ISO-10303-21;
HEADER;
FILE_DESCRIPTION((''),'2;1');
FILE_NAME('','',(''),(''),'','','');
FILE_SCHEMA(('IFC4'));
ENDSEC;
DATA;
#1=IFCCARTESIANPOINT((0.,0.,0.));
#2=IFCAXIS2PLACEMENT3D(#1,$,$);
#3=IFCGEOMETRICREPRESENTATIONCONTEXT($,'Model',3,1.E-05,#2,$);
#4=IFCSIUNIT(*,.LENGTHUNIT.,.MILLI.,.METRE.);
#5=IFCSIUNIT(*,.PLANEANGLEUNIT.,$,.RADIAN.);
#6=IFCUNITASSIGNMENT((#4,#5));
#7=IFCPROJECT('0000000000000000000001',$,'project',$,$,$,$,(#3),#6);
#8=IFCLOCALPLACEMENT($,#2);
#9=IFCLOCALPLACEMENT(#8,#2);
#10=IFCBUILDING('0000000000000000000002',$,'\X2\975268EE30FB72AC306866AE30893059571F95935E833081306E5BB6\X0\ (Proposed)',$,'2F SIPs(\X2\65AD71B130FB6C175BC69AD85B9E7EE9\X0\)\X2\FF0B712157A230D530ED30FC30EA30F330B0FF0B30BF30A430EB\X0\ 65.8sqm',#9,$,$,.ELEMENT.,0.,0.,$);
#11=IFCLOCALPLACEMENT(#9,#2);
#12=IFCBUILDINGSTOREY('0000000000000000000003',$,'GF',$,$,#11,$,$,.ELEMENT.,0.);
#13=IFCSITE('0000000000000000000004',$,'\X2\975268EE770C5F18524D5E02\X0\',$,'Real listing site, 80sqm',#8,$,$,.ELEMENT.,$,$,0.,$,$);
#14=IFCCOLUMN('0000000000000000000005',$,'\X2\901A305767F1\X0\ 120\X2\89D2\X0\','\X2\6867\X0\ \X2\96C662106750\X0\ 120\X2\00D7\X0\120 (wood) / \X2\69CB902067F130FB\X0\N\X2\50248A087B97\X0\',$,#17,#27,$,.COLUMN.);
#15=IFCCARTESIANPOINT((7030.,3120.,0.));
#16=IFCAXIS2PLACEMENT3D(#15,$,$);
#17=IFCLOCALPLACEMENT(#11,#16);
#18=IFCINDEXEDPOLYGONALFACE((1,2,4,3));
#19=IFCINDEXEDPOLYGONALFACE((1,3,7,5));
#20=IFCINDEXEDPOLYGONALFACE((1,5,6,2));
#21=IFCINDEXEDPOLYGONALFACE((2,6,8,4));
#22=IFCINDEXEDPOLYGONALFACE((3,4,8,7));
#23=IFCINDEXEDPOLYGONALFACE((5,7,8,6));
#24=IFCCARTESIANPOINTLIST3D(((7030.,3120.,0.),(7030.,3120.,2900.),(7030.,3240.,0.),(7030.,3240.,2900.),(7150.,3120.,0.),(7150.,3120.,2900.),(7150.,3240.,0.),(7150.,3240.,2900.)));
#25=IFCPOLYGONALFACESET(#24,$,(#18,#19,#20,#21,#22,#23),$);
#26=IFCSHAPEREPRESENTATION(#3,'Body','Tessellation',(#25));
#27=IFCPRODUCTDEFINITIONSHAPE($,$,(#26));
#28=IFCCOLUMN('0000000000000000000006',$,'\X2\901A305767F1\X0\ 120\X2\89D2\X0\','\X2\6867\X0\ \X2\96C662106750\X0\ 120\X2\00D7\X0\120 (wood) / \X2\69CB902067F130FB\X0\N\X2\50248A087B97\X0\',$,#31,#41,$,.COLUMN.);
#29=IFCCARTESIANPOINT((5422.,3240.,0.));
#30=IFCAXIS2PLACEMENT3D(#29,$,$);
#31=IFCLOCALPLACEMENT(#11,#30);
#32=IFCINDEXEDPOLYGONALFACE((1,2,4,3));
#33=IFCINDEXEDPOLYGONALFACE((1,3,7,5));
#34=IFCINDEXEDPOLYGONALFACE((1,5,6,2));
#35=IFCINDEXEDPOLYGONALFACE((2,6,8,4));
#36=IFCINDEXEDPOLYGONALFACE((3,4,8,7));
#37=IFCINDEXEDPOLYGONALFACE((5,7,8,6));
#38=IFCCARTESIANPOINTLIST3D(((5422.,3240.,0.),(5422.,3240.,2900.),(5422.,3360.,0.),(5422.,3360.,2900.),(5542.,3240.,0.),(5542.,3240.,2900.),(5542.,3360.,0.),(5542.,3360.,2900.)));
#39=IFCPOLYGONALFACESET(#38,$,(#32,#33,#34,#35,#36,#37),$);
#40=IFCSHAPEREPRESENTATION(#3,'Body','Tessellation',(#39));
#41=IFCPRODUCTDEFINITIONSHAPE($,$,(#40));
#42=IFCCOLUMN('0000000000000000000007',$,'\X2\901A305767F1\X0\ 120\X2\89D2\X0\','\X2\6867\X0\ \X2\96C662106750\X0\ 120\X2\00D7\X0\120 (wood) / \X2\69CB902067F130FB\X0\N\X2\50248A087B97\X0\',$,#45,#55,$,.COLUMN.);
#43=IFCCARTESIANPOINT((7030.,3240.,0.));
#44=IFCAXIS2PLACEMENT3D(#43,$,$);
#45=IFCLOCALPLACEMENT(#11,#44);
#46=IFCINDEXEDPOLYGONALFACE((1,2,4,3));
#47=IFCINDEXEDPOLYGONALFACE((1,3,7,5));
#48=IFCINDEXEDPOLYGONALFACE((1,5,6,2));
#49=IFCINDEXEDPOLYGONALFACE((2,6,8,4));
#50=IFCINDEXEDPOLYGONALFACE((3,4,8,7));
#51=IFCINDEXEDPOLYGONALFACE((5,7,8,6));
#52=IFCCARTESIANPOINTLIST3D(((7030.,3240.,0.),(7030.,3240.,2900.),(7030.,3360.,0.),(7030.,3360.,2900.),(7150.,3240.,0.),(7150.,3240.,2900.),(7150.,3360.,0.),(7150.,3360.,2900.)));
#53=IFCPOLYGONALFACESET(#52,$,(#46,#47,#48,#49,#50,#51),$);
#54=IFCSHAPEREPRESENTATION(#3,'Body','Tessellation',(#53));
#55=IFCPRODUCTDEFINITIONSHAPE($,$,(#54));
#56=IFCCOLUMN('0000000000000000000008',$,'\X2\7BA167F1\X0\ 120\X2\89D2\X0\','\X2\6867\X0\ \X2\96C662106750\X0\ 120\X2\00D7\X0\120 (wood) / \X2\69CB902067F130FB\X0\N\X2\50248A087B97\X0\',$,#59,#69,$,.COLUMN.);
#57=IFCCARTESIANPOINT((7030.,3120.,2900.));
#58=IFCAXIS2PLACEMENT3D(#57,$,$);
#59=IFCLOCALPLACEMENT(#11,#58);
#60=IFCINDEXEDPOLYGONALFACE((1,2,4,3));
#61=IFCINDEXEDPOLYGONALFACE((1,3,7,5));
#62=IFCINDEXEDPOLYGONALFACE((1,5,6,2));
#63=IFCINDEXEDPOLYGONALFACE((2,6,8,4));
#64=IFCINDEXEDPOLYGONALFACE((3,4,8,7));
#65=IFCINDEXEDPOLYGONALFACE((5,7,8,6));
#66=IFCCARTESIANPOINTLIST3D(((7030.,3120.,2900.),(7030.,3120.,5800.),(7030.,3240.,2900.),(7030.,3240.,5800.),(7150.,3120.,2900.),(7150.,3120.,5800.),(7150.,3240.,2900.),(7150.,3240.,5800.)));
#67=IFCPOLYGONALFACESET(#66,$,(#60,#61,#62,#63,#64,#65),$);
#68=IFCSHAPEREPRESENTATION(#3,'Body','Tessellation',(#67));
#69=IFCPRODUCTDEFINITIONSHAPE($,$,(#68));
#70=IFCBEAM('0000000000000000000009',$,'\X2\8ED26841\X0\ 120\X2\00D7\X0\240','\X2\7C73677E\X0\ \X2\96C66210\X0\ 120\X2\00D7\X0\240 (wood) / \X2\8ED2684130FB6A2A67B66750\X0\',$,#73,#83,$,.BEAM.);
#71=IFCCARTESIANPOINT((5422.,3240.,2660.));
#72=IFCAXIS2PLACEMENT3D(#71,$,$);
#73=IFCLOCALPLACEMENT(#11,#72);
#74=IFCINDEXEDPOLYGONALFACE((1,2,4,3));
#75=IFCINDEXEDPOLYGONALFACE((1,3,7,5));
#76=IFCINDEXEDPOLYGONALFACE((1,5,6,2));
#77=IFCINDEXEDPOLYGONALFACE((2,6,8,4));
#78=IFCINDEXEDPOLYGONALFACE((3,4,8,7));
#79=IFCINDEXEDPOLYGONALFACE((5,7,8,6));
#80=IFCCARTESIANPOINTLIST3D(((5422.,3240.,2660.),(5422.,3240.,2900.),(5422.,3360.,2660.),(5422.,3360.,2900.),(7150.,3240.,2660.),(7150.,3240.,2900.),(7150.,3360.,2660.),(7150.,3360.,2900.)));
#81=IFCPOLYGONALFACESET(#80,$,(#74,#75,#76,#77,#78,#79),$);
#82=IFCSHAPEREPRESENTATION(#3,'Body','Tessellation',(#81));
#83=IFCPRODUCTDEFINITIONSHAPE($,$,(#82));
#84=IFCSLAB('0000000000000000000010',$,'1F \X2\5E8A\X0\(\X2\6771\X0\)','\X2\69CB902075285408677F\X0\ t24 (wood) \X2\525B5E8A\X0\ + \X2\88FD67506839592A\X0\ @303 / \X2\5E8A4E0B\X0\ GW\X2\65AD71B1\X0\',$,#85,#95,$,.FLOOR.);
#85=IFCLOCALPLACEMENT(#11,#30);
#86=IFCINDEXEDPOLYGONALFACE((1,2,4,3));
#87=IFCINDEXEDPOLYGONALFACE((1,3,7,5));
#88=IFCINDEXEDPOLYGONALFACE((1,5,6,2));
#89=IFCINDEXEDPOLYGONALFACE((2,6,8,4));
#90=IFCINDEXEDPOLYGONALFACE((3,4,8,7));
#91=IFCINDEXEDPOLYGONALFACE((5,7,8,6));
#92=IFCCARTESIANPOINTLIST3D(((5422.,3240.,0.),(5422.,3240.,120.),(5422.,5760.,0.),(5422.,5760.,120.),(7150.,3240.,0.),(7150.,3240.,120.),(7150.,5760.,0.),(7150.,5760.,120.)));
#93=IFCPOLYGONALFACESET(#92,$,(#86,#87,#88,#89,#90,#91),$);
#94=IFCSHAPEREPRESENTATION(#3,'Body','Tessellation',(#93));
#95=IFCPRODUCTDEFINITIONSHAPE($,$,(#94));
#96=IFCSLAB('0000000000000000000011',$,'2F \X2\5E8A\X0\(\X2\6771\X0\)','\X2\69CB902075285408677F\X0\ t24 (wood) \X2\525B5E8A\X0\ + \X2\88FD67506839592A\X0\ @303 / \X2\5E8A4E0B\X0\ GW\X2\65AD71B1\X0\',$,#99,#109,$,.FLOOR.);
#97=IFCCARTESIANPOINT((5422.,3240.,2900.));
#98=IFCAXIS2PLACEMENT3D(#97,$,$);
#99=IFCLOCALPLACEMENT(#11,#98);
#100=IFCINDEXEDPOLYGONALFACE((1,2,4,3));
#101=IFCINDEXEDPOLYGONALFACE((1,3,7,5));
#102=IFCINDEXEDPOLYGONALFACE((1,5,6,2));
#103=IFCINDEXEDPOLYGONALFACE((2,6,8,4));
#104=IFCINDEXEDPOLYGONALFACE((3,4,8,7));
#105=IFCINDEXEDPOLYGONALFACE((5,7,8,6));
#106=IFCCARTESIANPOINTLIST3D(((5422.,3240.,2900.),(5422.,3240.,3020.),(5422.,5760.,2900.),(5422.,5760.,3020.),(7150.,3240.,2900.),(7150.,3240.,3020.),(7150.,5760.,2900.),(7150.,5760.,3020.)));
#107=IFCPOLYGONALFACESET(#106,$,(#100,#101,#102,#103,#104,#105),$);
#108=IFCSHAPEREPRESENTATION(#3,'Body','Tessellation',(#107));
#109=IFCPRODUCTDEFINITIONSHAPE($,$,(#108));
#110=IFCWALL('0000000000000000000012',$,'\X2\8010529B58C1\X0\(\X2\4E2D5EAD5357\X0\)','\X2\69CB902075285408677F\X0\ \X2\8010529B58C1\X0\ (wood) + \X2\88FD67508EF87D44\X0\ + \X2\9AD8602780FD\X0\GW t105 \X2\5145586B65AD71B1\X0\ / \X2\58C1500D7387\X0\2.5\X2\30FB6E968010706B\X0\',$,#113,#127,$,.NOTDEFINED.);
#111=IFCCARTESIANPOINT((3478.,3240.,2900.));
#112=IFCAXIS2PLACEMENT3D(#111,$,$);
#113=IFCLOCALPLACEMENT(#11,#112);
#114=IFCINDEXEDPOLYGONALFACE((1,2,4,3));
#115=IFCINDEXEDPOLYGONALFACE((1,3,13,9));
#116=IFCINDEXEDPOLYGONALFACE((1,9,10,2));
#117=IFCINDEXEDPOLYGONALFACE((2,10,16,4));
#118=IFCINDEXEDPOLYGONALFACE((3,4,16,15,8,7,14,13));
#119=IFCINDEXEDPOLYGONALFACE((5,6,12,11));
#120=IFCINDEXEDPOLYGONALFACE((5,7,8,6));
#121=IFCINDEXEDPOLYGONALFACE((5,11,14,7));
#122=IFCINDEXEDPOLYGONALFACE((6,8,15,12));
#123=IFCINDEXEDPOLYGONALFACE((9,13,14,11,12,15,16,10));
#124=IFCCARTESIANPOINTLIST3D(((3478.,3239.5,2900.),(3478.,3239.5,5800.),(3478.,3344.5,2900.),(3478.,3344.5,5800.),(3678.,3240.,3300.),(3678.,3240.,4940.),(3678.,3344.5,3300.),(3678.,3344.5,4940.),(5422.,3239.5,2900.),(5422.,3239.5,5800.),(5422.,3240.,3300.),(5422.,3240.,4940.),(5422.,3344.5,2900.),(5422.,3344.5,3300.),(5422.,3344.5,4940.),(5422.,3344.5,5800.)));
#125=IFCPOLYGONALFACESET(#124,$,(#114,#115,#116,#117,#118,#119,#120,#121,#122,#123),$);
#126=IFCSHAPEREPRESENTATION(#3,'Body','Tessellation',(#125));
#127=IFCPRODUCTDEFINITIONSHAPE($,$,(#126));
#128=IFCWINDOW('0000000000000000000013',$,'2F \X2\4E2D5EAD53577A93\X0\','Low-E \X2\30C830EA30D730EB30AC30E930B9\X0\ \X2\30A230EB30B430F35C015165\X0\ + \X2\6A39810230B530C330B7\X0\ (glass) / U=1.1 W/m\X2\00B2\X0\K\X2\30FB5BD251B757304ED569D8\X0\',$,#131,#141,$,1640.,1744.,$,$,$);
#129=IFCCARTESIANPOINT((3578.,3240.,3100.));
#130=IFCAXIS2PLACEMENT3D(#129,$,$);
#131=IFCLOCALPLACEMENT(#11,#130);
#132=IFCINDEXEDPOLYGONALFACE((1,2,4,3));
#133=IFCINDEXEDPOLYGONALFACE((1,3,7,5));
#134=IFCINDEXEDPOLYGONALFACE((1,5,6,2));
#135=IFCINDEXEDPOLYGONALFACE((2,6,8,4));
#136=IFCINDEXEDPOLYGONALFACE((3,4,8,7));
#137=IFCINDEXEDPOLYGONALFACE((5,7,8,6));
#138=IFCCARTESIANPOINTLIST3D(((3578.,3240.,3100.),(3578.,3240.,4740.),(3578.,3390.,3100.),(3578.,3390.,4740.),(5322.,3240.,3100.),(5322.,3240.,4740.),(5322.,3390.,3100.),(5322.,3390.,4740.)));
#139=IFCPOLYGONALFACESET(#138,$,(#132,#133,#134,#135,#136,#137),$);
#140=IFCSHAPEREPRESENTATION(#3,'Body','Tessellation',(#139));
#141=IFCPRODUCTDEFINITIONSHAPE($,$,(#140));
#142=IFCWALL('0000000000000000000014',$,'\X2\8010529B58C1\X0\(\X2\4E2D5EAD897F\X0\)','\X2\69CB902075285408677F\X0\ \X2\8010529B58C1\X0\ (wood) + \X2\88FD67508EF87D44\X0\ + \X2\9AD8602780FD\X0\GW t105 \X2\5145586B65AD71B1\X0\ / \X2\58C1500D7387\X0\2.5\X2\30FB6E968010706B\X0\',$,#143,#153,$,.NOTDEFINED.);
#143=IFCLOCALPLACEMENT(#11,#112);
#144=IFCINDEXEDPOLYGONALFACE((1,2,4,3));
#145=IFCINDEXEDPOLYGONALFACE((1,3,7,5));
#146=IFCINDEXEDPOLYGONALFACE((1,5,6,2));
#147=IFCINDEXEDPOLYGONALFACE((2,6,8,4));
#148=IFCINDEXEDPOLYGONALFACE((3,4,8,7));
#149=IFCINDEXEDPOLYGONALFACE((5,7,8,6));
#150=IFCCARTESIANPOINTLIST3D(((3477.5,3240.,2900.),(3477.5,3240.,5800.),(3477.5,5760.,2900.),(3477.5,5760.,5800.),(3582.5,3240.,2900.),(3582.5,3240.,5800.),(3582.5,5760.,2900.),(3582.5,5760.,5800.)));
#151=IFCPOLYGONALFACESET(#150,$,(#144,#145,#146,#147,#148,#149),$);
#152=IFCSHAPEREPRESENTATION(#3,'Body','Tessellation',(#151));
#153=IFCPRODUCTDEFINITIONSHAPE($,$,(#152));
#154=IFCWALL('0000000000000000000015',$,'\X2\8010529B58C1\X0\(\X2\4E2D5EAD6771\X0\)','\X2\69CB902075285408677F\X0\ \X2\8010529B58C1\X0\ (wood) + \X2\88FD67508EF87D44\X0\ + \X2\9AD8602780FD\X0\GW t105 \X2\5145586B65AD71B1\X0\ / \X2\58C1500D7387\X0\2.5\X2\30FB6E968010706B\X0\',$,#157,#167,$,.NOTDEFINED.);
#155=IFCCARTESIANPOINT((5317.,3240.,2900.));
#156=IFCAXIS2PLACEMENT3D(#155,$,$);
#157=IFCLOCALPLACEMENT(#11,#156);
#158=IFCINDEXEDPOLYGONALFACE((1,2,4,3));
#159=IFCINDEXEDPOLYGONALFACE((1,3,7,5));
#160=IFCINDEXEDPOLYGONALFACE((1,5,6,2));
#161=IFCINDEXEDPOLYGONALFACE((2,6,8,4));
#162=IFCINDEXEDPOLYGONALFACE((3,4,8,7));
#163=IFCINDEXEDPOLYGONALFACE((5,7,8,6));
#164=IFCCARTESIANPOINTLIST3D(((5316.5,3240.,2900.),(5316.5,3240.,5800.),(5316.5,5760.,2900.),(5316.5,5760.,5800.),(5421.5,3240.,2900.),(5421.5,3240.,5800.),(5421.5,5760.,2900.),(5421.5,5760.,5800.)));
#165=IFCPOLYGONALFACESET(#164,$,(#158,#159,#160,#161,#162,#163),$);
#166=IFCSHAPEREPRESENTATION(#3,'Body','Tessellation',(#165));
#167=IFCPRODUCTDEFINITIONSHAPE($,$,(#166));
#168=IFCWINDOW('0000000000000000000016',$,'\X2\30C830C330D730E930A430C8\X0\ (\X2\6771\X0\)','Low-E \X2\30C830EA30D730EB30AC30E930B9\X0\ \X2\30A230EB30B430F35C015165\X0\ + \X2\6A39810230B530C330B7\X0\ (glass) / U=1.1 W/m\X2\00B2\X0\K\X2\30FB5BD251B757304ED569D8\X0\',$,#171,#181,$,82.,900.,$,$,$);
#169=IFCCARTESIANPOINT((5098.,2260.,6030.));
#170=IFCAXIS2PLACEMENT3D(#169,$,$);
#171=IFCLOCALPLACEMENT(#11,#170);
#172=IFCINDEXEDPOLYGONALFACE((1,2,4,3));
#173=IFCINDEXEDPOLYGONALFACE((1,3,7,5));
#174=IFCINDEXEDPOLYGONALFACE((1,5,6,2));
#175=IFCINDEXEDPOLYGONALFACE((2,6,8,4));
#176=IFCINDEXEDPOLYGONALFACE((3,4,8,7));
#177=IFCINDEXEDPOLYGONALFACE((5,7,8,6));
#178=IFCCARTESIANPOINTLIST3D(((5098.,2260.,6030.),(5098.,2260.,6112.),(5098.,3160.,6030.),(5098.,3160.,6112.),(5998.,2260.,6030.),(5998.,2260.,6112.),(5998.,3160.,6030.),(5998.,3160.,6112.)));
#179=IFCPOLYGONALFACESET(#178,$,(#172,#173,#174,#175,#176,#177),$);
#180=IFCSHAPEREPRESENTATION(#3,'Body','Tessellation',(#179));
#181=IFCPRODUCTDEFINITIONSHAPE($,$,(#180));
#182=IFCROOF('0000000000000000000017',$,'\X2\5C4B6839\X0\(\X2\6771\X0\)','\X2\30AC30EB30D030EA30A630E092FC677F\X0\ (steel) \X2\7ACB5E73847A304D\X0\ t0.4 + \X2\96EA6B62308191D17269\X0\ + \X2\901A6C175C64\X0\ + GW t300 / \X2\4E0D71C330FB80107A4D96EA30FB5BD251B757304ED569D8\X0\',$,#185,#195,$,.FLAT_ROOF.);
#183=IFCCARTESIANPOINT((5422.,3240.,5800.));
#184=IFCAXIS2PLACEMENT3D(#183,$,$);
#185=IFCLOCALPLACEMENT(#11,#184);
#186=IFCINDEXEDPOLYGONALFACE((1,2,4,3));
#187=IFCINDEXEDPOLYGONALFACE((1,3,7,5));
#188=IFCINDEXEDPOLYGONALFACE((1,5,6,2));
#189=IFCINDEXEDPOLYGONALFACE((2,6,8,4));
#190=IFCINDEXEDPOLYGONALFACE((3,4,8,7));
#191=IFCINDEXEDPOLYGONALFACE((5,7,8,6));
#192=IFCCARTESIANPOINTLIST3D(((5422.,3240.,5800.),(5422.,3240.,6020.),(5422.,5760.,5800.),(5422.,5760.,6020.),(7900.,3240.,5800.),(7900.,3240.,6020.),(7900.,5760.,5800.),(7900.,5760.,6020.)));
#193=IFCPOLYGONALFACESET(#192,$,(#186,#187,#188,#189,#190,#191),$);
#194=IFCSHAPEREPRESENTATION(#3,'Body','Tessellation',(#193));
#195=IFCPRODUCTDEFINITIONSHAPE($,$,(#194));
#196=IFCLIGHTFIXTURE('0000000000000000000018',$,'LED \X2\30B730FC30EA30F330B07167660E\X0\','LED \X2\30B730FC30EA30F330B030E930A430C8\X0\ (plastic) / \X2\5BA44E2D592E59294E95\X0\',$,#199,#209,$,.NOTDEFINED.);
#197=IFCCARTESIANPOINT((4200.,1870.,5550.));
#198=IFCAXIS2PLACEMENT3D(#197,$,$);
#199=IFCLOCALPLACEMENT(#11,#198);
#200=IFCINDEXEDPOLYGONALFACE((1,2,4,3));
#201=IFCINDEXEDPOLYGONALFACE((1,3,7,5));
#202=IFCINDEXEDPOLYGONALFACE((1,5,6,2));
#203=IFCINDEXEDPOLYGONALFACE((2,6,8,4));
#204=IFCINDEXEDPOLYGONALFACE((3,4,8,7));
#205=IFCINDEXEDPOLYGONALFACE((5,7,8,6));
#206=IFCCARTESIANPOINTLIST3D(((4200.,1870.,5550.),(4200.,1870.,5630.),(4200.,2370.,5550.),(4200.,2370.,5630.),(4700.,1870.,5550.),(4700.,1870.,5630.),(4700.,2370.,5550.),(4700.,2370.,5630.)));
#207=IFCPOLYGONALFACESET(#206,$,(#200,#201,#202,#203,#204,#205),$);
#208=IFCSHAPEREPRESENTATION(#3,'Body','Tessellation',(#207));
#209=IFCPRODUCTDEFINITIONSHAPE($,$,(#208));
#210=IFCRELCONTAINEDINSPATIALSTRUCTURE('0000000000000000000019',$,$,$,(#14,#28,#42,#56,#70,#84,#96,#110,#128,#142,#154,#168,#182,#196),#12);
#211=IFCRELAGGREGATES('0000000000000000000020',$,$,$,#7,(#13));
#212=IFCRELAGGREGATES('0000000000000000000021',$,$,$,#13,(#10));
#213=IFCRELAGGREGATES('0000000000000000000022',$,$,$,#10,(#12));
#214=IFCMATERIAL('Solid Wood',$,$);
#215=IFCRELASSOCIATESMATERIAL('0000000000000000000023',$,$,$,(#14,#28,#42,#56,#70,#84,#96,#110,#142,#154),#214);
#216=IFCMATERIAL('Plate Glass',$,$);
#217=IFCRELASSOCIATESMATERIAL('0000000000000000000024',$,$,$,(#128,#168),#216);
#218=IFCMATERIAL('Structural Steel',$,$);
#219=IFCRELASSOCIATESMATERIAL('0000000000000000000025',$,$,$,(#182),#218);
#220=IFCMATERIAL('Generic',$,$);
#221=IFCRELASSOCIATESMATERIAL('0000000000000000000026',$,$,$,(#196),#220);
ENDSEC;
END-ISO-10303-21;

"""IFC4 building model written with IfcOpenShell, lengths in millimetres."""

from ifc_helpers import new_model, si_unit, frame, frame_2d, origin, place, context, project, spatial, rectangle, extrude, material, element, fill, save


model = new_model("IFC4")

# Units and contexts
model_context = context("Model", 3, precision=1e-05, world=origin())
ifc_project = project(units=[si_unit("LENGTHUNIT", "METRE", prefix="MILLI"), si_unit("PLANEANGLEUNIT", "RADIAN")], contexts=[model_context])

# Site, building, storey
site_placement = place(None, origin())
site = spatial("IfcSite", under=ifc_project, at=site_placement, Name="青森県弘前市", ObjectType="Real listing site, 80sqm", CompositionType="ELEMENT", RefElevation=0.0)
building_placement = place(site_placement, origin())
building = spatial("IfcBuilding", under=site, at=building_placement, Name="青森・犬と暮らす土間広めの家 (Proposed)", ObjectType="2F SIPs(断熱・気密高实绩)＋無垢フローリング＋タイル 65.8sqm", CompositionType="ELEMENT", ElevationOfRefHeight=0.0, ElevationOfTerrain=0.0)
storey_placement = place(building_placement, origin())
storey = spatial("IfcBuildingStorey", under=building, at=storey_placement, Name="GF", CompositionType="ELEMENT", Elevation=0.0)

# Columns
ifc_material_1 = material(Name="Solid Wood")
column_1_placement = place(storey_placement, frame((7030.0, 3120.0, 0.0)))
element("IfcColumn", 1, at=column_1_placement, inside=storey, material=ifc_material_1, Name="通し柱 120角", Description="桧 集成材 120×120 (wood) / 構造柱・N値計算", PredefinedType="COLUMN", context=model_context, shape_type="SweptSolid", body=[
    extrude(rectangle(XDim=120.0, YDim=120.0, at=frame_2d((60.0, 60.0))), frame((7030.0, 3120.0, 0.0)), (0.0, 0.0, 1.0), 2900.0),
])
column_2_placement = place(storey_placement, frame((5422.0, 3240.0, 0.0)))
element("IfcColumn", 2, at=column_2_placement, inside=storey, material=ifc_material_1, Name="通し柱 120角", Description="桧 集成材 120×120 (wood) / 構造柱・N値計算", PredefinedType="COLUMN", context=model_context, shape_type="SweptSolid", body=[
    extrude(rectangle(XDim=120.0, YDim=120.0, at=frame_2d((60.0, 60.0))), frame((5422.0, 3240.0, 0.0)), (0.0, 0.0, 1.0), 2900.0),
])
column_3_placement = place(storey_placement, frame((7030.0, 3240.0, 0.0)))
element("IfcColumn", 3, at=column_3_placement, inside=storey, material=ifc_material_1, Name="通し柱 120角", Description="桧 集成材 120×120 (wood) / 構造柱・N値計算", PredefinedType="COLUMN", context=model_context, shape_type="SweptSolid", body=[
    extrude(rectangle(XDim=120.0, YDim=120.0, at=frame_2d((60.0, 60.0))), frame((7030.0, 3240.0, 0.0)), (0.0, 0.0, 1.0), 2900.0),
])
column_4_placement = place(storey_placement, frame((7030.0, 3120.0, 2900.0)))
element("IfcColumn", 4, at=column_4_placement, inside=storey, material=ifc_material_1, Name="管柱 120角", Description="桧 集成材 120×120 (wood) / 構造柱・N値計算", PredefinedType="COLUMN", context=model_context, shape_type="SweptSolid", body=[
    extrude(rectangle(XDim=120.0, YDim=120.0, at=frame_2d((60.0, 60.0))), frame((7030.0, 3120.0, 2900.0)), (0.0, 0.0, 1.0), 2900.0),
])

# Beam
beam_1_placement = place(storey_placement, frame((5422.0, 3240.0, 2660.0)))
element("IfcBeam", 5, at=beam_1_placement, inside=storey, material=ifc_material_1, Name="軒桁 120×240", Description="米松 集成 120×240 (wood) / 軒桁・横架材", PredefinedType="BEAM", context=model_context, shape_type="SweptSolid", body=[
    extrude(rectangle(XDim=1728.0, YDim=120.0, at=frame_2d((864.0, 60.0))), frame((5422.0, 3240.0, 2660.0)), (0.0, 0.0, 1.0), 240.0),
])

# Slabs
slab_1_placement = place(storey_placement, frame((5422.0, 3240.0, 0.0)))
element("IfcSlab", 6, at=slab_1_placement, inside=storey, material=ifc_material_1, Name="1F 床(東)", Description="構造用合板 t24 (wood) 剛床 + 製材根太 @303 / 床下 GW断熱", PredefinedType="FLOOR", context=model_context, shape_type="SweptSolid", body=[
    extrude(rectangle(XDim=1728.0, YDim=2520.0, at=frame_2d((864.0, 1260.0))), frame((5422.0, 3240.0, 0.0)), (0.0, 0.0, 1.0), 120.0),
])
slab_2_placement = place(storey_placement, frame((5422.0, 3240.0, 2900.0)))
element("IfcSlab", 7, at=slab_2_placement, inside=storey, material=ifc_material_1, Name="2F 床(東)", Description="構造用合板 t24 (wood) 剛床 + 製材根太 @303 / 床下 GW断熱", PredefinedType="FLOOR", context=model_context, shape_type="SweptSolid", body=[
    extrude(rectangle(XDim=1728.0, YDim=2520.0, at=frame_2d((864.0, 1260.0))), frame((5422.0, 3240.0, 2900.0)), (0.0, 0.0, 1.0), 120.0),
])

# Wall, opening, window
wall_1_placement = place(storey_placement, frame((3478.0, 3240.0, 2900.0)))
wall_1 = element("IfcWall", 8, at=wall_1_placement, inside=storey, material=ifc_material_1, Name="耐力壁(中庭南)", Description="構造用合板 耐力壁 (wood) + 製材軸組 + 高性能GW t105 充填断熱 / 壁倍率2.5・準耐火", PredefinedType="NOTDEFINED", context=model_context, shape_type="SweptSolid", body=[
    extrude(rectangle(XDim=1944.0, YDim=105.0, at=frame_2d((972.0, 52.0))), frame((3478.0, 3240.0, 2900.0)), (0.0, 0.0, 1.0), 2900.0),
])
opening_placement = place(storey_placement, frame((3578.0, 3240.0, 3100.0)))
opening = element("IfcOpeningElement", 9, at=opening_placement, cuts=wall_1, PredefinedType="NOTDEFINED", context=model_context, shape_type="SweptSolid", body=[
    extrude(rectangle(XDim=1744.0, YDim=150.0, at=frame_2d((872.0, 75.0))), frame((3578.0, 3240.0, 3100.0)), (0.0, 0.0, 1.0), 1640.0),
])
ifc_material_2 = material(Name="Plate Glass")
window_1_placement = place(storey_placement, frame((3578.0, 3240.0, 3100.0)))
window_1 = element("IfcWindow", 10, at=window_1_placement, inside=storey, material=ifc_material_2, Name="2F 中庭南窓", Description="Low-E トリプルガラス アルゴン封入 + 樹脂サッシ (glass) / U=1.1 W/m²K・寒冷地仕様", OverallHeight=1640.0, OverallWidth=1744.0, context=model_context, shape_type="SweptSolid", body=[
    extrude(rectangle(XDim=1744.0, YDim=150.0, at=frame_2d((872.0, 75.0))), frame((3578.0, 3240.0, 3100.0)), (0.0, 0.0, 1.0), 1640.0),
])
fill(opening, window_1)

# Walls
wall_2_placement = place(storey_placement, frame((3478.0, 3240.0, 2900.0)))
element("IfcWall", 11, at=wall_2_placement, inside=storey, material=ifc_material_1, Name="耐力壁(中庭西)", Description="構造用合板 耐力壁 (wood) + 製材軸組 + 高性能GW t105 充填断熱 / 壁倍率2.5・準耐火", PredefinedType="NOTDEFINED", context=model_context, shape_type="SweptSolid", body=[
    extrude(rectangle(XDim=105.0, YDim=2520.0, at=frame_2d((52.0, 1260.0))), frame((3478.0, 3240.0, 2900.0)), (0.0, 0.0, 1.0), 2900.0),
])
wall_3_placement = place(storey_placement, frame((5317.0, 3240.0, 2900.0)))
element("IfcWall", 12, at=wall_3_placement, inside=storey, material=ifc_material_1, Name="耐力壁(中庭東)", Description="構造用合板 耐力壁 (wood) + 製材軸組 + 高性能GW t105 充填断熱 / 壁倍率2.5・準耐火", PredefinedType="NOTDEFINED", context=model_context, shape_type="SweptSolid", body=[
    extrude(rectangle(XDim=105.0, YDim=2520.0, at=frame_2d((52.0, 1260.0))), frame((5317.0, 3240.0, 2900.0)), (0.0, 0.0, 1.0), 2900.0),
])

# Window
window_2_placement = place(storey_placement, frame((5098.0, 2260.0, 6030.0)))
element("IfcWindow", 13, at=window_2_placement, inside=storey, material=ifc_material_2, Name="トップライト (東)", Description="Low-E トリプルガラス アルゴン封入 + 樹脂サッシ (glass) / U=1.1 W/m²K・寒冷地仕様", OverallHeight=82.0, OverallWidth=900.0, context=model_context, shape_type="SweptSolid", body=[
    extrude(rectangle(XDim=900.0, YDim=900.0, at=frame_2d((450.0, 450.0))), frame((5098.0, 2260.0, 6030.0)), (0.0, 0.0, 1.0), 82.0),
])

# Roof
ifc_material_3 = material(Name="Structural Steel")
for number, where, name in (
    (14, (5422.0, 3240.0, 5800.0), "屋根(東)"),
):
    element("IfcRoof", number, at=place(storey_placement, frame(where)), inside=storey, material=ifc_material_3, Name=name, Description="ガルバリウム鋼板 (steel) 立平葺き t0.4 + 雪止め金物 + 通気層 + GW t300 / 不燃・耐積雪・寒冷地仕様", PredefinedType="FLAT_ROOF", context=model_context, shape_type="SweptSolid", body=[
        extrude(rectangle(XDim=2478.0, YDim=2520.0, at=frame_2d((1239.0, 1260.0))), frame((5422.0, 3240.0, 5800.0)), (0.0, 0.0, 1.0), 220.0),
    ])

# Light fixture
ifc_material_4 = material(Name="Generic")
light_fixture_placement = place(storey_placement, frame((4200.0, 1870.0, 5550.0)))
element("IfcLightFixture", 15, at=light_fixture_placement, inside=storey, material=ifc_material_4, Name="LED シーリング照明", Description="LED シーリングライト (plastic) / 室中央天井", PredefinedType="NOTDEFINED", context=model_context, shape_type="SweptSolid", body=[
    extrude(rectangle(XDim=500.0, YDim=500.0, at=frame_2d((250.0, 250.0))), frame((4200.0, 1870.0, 5550.0)), (0.0, 0.0, 1.0), 80.0),
])

save(model, "model.ifc")
